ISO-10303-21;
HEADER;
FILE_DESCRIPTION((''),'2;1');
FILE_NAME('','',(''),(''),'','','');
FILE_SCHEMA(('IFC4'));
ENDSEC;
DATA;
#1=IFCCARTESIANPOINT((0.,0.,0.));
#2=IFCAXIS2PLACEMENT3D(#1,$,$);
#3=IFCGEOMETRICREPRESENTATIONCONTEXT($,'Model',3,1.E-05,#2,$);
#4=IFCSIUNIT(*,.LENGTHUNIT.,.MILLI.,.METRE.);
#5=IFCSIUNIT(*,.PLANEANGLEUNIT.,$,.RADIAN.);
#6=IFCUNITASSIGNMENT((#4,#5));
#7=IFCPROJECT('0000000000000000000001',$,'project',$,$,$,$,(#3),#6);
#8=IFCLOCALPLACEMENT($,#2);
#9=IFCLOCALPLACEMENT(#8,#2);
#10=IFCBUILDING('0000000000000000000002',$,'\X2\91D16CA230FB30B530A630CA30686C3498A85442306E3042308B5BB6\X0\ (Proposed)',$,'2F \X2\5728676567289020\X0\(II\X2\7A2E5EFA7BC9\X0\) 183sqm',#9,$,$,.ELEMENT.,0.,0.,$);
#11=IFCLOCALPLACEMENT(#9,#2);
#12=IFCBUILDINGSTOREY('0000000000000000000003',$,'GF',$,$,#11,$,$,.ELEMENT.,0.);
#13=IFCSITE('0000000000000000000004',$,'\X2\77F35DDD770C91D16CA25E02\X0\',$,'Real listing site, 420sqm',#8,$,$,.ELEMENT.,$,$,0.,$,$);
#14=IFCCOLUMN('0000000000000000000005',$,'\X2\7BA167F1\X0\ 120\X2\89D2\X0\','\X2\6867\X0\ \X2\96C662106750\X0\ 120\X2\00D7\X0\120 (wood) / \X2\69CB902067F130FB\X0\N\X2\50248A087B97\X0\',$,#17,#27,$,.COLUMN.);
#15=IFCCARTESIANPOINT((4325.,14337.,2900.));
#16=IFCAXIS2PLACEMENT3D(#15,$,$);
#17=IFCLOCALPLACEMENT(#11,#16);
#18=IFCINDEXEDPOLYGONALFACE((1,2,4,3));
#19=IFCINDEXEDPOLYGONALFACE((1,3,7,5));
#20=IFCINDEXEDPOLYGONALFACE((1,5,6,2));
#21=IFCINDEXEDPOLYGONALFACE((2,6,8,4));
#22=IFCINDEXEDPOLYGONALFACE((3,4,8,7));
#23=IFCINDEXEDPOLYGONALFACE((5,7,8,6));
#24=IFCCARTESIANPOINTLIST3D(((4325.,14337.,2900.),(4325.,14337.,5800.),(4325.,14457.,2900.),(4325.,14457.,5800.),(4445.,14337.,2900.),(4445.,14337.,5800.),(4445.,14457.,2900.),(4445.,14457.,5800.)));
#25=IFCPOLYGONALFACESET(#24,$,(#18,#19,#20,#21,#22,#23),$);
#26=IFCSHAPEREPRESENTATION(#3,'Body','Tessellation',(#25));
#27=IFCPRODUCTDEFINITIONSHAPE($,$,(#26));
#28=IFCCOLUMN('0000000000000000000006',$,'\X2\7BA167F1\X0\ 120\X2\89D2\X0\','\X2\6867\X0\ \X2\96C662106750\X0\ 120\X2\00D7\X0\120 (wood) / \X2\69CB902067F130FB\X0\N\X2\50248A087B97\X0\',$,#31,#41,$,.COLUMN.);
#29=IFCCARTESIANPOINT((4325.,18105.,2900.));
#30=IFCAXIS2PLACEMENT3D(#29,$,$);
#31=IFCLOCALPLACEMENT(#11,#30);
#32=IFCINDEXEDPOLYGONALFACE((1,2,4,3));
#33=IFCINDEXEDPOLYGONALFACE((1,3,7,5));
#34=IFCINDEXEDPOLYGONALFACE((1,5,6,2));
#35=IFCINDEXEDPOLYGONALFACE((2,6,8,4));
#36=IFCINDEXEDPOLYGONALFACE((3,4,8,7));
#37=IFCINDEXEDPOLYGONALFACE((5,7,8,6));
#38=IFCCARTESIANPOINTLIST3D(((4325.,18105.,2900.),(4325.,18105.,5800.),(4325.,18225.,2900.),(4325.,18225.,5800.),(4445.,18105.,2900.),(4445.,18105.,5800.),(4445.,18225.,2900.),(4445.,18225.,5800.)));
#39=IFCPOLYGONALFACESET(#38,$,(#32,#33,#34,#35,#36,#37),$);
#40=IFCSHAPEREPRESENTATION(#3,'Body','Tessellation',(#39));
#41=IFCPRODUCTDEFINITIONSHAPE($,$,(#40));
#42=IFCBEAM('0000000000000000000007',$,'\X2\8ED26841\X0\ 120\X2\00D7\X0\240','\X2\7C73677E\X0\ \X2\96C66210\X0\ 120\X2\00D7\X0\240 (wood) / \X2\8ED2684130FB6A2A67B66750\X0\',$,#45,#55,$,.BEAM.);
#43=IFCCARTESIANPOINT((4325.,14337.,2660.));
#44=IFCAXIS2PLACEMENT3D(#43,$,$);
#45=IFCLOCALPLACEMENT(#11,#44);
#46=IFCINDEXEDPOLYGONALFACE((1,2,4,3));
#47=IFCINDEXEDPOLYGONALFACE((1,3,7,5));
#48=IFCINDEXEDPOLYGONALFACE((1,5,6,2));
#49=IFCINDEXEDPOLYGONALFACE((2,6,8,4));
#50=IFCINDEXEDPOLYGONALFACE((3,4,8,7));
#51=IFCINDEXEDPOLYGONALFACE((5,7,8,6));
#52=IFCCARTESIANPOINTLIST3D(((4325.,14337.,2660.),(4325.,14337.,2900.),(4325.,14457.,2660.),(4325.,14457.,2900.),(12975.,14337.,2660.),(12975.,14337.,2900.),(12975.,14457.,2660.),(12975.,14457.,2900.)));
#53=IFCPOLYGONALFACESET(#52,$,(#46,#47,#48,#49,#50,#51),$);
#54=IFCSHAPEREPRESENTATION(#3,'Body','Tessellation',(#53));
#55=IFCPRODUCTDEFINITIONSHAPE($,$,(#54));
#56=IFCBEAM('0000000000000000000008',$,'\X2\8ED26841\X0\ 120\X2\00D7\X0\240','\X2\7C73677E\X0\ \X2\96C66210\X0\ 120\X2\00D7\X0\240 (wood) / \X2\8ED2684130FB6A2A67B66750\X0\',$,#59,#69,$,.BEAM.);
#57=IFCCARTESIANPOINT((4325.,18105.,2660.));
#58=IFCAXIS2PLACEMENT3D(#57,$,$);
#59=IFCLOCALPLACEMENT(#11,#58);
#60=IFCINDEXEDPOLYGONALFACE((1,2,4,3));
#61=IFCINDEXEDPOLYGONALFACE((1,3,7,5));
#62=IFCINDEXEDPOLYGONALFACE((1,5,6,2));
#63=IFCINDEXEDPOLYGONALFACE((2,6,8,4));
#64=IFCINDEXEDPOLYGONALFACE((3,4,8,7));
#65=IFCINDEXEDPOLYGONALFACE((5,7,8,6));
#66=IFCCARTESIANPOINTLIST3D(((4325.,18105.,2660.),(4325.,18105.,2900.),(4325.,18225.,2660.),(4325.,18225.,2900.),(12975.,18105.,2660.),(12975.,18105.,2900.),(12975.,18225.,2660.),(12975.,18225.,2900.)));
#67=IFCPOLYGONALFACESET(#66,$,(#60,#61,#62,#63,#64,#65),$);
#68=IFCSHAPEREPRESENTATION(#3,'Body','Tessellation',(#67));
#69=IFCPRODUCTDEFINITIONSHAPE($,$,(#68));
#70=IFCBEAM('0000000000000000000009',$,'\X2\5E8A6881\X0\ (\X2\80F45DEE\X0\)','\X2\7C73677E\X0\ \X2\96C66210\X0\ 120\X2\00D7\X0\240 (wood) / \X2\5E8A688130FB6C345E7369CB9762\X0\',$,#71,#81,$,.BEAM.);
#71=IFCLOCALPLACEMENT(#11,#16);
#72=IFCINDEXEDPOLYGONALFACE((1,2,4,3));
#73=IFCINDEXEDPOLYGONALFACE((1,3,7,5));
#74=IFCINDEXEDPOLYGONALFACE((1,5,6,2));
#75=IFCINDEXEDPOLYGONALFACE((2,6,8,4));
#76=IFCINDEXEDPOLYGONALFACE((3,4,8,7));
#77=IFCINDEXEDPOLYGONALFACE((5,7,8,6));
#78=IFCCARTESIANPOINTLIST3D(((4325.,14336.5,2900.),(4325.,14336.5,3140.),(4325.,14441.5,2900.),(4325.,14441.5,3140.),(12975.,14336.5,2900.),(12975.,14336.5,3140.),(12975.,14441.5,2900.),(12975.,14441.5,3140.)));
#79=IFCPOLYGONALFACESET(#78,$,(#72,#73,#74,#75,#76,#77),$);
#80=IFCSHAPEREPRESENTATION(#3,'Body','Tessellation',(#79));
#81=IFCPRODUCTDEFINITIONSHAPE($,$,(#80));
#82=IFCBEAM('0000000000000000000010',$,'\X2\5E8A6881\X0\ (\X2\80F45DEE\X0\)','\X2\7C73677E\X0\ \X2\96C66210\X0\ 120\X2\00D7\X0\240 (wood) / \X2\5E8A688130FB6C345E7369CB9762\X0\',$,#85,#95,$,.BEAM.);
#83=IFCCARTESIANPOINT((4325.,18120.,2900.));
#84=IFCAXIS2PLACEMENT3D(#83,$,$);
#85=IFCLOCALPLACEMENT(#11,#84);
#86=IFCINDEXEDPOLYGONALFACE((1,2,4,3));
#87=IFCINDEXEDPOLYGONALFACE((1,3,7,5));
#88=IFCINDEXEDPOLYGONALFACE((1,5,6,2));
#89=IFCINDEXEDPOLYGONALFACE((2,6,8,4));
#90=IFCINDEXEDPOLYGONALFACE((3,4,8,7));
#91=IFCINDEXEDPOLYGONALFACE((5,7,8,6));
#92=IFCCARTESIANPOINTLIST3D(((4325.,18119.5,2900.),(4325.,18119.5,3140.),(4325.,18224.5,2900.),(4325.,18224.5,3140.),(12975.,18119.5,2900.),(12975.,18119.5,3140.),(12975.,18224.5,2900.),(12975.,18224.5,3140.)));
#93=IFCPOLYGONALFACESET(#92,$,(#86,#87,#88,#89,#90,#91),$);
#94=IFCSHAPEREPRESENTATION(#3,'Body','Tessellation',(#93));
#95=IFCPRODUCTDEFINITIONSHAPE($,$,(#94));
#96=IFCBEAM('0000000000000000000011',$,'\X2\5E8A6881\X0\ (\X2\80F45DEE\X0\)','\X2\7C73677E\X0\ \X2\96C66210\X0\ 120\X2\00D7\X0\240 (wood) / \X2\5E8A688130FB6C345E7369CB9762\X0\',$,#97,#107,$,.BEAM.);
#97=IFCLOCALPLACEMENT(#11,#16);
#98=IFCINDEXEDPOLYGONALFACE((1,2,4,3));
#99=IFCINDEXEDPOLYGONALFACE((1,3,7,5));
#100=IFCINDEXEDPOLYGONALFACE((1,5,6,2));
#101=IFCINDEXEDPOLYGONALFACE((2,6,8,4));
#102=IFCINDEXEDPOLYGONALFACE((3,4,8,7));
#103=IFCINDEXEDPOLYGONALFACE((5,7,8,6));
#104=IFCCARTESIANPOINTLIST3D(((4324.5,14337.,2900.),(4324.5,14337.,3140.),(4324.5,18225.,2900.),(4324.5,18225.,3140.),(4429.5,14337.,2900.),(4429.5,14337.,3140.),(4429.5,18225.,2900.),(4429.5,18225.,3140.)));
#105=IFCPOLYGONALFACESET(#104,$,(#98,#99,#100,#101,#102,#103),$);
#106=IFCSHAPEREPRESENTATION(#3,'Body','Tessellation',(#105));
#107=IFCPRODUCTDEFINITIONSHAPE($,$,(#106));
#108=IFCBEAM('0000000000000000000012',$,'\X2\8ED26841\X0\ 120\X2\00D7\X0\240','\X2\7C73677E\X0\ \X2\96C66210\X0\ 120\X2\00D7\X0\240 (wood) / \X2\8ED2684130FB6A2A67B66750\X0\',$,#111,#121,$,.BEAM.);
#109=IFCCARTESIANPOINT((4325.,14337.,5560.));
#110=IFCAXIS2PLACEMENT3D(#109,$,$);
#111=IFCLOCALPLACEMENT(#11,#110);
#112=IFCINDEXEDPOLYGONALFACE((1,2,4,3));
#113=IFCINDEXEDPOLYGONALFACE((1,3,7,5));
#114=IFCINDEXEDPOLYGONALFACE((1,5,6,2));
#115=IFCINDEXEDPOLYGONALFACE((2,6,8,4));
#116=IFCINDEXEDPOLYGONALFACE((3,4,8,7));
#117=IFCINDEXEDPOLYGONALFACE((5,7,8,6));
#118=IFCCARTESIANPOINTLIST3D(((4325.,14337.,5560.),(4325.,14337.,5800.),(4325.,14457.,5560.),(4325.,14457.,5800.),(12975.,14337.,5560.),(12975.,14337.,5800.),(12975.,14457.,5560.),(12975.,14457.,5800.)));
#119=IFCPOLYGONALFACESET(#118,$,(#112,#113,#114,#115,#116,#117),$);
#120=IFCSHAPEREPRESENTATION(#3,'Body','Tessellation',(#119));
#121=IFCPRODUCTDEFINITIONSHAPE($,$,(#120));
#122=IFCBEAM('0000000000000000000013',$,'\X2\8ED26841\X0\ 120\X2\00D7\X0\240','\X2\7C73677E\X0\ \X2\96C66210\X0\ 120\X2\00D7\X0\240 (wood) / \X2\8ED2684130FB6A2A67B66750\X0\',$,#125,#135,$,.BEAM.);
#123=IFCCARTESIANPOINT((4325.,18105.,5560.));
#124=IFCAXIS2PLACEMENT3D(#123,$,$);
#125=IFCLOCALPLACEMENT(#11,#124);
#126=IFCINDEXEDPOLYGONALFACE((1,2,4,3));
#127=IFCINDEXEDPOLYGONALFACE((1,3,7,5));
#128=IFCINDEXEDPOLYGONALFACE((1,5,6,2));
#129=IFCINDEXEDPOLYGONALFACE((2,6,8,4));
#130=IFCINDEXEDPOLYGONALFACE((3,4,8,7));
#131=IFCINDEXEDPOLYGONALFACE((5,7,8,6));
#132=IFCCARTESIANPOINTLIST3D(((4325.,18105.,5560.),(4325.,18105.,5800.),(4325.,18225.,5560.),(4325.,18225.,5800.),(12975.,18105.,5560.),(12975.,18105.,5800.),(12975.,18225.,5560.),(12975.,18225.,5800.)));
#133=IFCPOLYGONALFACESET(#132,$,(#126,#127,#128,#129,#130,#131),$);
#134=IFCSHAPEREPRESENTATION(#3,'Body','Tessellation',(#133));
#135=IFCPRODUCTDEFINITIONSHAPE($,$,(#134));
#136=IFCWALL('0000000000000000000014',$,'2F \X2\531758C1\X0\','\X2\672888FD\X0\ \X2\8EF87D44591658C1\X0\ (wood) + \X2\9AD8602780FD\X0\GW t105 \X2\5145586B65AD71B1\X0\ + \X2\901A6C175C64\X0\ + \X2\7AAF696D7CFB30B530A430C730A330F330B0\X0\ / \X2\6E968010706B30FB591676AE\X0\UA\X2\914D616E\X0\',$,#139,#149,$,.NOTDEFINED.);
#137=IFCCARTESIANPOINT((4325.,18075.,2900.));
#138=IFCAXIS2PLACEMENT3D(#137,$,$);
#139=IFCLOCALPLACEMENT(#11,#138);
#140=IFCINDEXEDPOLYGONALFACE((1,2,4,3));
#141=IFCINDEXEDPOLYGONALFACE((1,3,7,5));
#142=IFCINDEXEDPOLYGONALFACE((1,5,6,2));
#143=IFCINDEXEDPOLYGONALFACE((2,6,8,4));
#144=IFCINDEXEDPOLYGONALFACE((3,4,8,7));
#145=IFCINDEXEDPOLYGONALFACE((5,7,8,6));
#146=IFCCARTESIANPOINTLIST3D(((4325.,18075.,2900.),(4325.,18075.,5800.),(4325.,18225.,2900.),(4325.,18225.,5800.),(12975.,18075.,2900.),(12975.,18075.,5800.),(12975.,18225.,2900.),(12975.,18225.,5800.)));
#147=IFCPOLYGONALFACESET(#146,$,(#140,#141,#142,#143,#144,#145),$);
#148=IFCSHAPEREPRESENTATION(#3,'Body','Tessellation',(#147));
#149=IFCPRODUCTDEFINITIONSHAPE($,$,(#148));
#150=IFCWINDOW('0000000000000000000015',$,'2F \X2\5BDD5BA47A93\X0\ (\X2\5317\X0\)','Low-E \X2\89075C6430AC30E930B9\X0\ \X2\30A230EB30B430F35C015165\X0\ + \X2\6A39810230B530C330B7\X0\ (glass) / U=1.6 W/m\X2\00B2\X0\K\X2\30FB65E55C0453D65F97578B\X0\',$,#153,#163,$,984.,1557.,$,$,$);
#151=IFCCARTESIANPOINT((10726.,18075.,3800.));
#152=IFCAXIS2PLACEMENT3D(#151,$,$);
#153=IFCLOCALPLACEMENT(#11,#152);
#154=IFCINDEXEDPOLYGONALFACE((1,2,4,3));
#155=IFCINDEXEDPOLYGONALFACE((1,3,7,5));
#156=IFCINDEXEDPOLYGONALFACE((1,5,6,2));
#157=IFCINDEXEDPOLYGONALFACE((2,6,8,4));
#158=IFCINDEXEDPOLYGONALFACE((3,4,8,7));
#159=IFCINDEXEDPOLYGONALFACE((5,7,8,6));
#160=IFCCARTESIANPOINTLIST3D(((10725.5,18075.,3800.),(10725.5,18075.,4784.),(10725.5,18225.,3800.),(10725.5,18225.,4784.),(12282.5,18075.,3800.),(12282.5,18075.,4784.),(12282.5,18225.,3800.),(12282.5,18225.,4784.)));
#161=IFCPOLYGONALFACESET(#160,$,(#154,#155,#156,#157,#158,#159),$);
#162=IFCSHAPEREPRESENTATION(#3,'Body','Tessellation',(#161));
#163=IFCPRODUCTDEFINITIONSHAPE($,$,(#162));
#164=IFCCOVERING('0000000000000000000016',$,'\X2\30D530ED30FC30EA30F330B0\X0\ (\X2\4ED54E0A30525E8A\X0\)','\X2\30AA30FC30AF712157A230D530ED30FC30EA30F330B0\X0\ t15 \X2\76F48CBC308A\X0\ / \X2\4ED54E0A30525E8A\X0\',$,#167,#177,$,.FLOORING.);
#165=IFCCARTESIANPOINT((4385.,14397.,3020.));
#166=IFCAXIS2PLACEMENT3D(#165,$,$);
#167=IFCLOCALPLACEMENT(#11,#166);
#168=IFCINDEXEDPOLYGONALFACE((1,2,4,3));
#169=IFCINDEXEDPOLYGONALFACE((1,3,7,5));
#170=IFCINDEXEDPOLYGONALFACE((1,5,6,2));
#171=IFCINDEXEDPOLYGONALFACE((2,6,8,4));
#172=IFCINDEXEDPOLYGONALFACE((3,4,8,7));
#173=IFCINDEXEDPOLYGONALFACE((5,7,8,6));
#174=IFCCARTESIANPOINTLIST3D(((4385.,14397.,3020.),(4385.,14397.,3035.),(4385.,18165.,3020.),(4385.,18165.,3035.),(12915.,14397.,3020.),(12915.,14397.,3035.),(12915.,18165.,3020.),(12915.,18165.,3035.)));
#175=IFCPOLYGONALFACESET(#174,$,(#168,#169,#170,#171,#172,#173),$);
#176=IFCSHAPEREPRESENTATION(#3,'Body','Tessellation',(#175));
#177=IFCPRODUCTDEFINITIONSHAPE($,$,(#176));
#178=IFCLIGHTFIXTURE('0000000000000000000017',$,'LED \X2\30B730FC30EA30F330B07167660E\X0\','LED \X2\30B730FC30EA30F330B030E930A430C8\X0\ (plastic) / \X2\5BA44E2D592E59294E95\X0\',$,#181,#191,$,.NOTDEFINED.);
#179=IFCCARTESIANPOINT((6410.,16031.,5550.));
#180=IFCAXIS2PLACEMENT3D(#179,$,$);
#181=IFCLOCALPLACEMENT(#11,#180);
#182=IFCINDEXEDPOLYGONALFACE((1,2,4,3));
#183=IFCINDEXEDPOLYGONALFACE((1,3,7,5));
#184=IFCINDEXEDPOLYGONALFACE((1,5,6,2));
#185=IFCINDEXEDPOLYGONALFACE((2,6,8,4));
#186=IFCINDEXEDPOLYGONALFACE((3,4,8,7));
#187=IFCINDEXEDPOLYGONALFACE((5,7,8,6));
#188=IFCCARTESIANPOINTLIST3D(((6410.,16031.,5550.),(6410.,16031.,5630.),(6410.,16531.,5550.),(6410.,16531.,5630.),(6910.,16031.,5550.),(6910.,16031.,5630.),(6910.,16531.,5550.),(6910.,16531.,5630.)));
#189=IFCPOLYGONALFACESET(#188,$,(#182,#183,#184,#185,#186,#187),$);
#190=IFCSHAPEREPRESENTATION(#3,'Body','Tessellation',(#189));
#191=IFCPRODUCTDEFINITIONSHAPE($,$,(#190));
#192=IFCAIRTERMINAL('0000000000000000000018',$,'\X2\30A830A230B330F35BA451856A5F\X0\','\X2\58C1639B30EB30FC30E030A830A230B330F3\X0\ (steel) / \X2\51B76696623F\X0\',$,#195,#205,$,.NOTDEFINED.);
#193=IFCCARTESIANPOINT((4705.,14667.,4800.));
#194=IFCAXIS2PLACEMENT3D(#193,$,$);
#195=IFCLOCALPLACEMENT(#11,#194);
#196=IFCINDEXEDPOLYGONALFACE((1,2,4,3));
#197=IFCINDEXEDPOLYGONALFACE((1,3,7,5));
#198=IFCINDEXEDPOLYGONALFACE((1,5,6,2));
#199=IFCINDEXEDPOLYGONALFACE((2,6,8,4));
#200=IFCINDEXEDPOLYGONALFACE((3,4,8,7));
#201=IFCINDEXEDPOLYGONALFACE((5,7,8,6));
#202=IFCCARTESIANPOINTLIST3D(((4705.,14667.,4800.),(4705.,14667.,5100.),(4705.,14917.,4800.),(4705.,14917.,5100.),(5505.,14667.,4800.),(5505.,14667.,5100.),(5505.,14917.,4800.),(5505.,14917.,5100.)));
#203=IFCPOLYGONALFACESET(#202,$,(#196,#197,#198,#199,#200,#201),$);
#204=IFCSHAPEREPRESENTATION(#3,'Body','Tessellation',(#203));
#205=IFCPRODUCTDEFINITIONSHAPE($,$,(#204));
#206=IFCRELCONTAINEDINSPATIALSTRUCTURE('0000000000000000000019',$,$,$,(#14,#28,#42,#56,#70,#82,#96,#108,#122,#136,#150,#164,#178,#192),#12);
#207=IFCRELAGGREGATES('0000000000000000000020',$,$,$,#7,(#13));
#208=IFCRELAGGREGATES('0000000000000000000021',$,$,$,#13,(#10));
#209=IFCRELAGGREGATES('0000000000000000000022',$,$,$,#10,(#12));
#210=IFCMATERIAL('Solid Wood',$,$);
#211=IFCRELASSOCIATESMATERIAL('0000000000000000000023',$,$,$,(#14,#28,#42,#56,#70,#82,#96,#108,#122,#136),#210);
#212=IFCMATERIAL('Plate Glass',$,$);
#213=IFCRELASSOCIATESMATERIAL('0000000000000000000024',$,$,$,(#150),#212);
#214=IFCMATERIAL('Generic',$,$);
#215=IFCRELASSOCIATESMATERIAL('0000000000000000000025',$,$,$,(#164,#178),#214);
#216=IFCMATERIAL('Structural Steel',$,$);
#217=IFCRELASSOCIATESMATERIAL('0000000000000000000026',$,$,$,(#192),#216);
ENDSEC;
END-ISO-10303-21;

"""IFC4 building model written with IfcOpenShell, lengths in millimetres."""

from ifc_helpers import new_model, si_unit, frame, frame_2d, origin, place, context, project, spatial, rectangle, extrude, material, element, fill, save


model = new_model("IFC4")

# Units and contexts
model_context = context("Model", 3, precision=1e-05, world=origin())
ifc_project = project(units=[si_unit("LENGTHUNIT", "METRE", prefix="MILLI"), si_unit("PLANEANGLEUNIT", "RADIAN")], contexts=[model_context])

# Site, building, storey
site_placement = place(None, origin())
site = spatial("IfcSite", under=ifc_project, at=site_placement, Name="石川県金沢市", ObjectType="Real listing site, 420sqm", CompositionType="ELEMENT", RefElevation=0.0)
building_placement = place(site_placement, origin())
building = spatial("IfcBuilding", under=site, at=building_placement, Name="金沢・サウナと水風呂のある家 (Proposed)", ObjectType="2F 在来木造(II種建築) 183sqm", CompositionType="ELEMENT", ElevationOfRefHeight=0.0, ElevationOfTerrain=0.0)
storey_placement = place(building_placement, origin())
storey = spatial("IfcBuildingStorey", under=building, at=storey_placement, Name="GF", CompositionType="ELEMENT", Elevation=0.0)

# Columns
ifc_material_1 = material(Name="Solid Wood")
column_1_placement = place(storey_placement, frame((4325.0, 14337.0, 2900.0)))
element("IfcColumn", 1, at=column_1_placement, inside=storey, material=ifc_material_1, Name="管柱 120角", Description="桧 集成材 120×120 (wood) / 構造柱・N値計算", PredefinedType="COLUMN", context=model_context, shape_type="SweptSolid", body=[
    extrude(rectangle(XDim=120.0, YDim=120.0, at=frame_2d((60.0, 60.0))), frame((4325.0, 14337.0, 2900.0)), (0.0, 0.0, 1.0), 2900.0),
])
column_2_placement = place(storey_placement, frame((4325.0, 18105.0, 2900.0)))
element("IfcColumn", 2, at=column_2_placement, inside=storey, material=ifc_material_1, Name="管柱 120角", Description="桧 集成材 120×120 (wood) / 構造柱・N値計算", PredefinedType="COLUMN", context=model_context, shape_type="SweptSolid", body=[
    extrude(rectangle(XDim=120.0, YDim=120.0, at=frame_2d((60.0, 60.0))), frame((4325.0, 18105.0, 2900.0)), (0.0, 0.0, 1.0), 2900.0),
])

# Beams
beam_1_placement = place(storey_placement, frame((4325.0, 14337.0, 2660.0)))
element("IfcBeam", 3, at=beam_1_placement, inside=storey, material=ifc_material_1, Name="軒桁 120×240", Description="米松 集成 120×240 (wood) / 軒桁・横架材", PredefinedType="BEAM", context=model_context, shape_type="SweptSolid", body=[
    extrude(rectangle(XDim=8650.0, YDim=120.0, at=frame_2d((4325.0, 60.0))), frame((4325.0, 14337.0, 2660.0)), (0.0, 0.0, 1.0), 240.0),
])
beam_2_placement = place(storey_placement, frame((4325.0, 18105.0, 2660.0)))
element("IfcBeam", 4, at=beam_2_placement, inside=storey, material=ifc_material_1, Name="軒桁 120×240", Description="米松 集成 120×240 (wood) / 軒桁・横架材", PredefinedType="BEAM", context=model_context, shape_type="SweptSolid", body=[
    extrude(rectangle(XDim=8650.0, YDim=120.0, at=frame_2d((4325.0, 60.0))), frame((4325.0, 18105.0, 2660.0)), (0.0, 0.0, 1.0), 240.0),
])
beam_3_placement = place(storey_placement, frame((4325.0, 14337.0, 2900.0)))
element("IfcBeam", 5, at=beam_3_placement, inside=storey, material=ifc_material_1, Name="床梁 (胴差)", Description="米松 集成 120×240 (wood) / 床梁・水平構面", PredefinedType="BEAM", context=model_context, shape_type="SweptSolid", body=[
    extrude(rectangle(XDim=8650.0, YDim=105.0, at=frame_2d((4325.0, 52.0))), frame((4325.0, 14337.0, 2900.0)), (0.0, 0.0, 1.0), 240.0),
])
beam_4_placement = place(storey_placement, frame((4325.0, 18120.0, 2900.0)))
element("IfcBeam", 6, at=beam_4_placement, inside=storey, material=ifc_material_1, Name="床梁 (胴差)", Description="米松 集成 120×240 (wood) / 床梁・水平構面", PredefinedType="BEAM", context=model_context, shape_type="SweptSolid", body=[
    extrude(rectangle(XDim=8650.0, YDim=105.0, at=frame_2d((4325.0, 52.0))), frame((4325.0, 18120.0, 2900.0)), (0.0, 0.0, 1.0), 240.0),
])
beam_5_placement = place(storey_placement, frame((4325.0, 14337.0, 2900.0)))
element("IfcBeam", 7, at=beam_5_placement, inside=storey, material=ifc_material_1, Name="床梁 (胴差)", Description="米松 集成 120×240 (wood) / 床梁・水平構面", PredefinedType="BEAM", context=model_context, shape_type="SweptSolid", body=[
    extrude(rectangle(XDim=105.0, YDim=3888.0, at=frame_2d((52.0, 1944.0))), frame((4325.0, 14337.0, 2900.0)), (0.0, 0.0, 1.0), 240.0),
])
beam_6_placement = place(storey_placement, frame((4325.0, 14337.0, 5560.0)))
element("IfcBeam", 8, at=beam_6_placement, inside=storey, material=ifc_material_1, Name="軒桁 120×240", Description="米松 集成 120×240 (wood) / 軒桁・横架材", PredefinedType="BEAM", context=model_context, shape_type="SweptSolid", body=[
    extrude(rectangle(XDim=8650.0, YDim=120.0, at=frame_2d((4325.0, 60.0))), frame((4325.0, 14337.0, 5560.0)), (0.0, 0.0, 1.0), 240.0),
])
beam_7_placement = place(storey_placement, frame((4325.0, 18105.0, 5560.0)))
element("IfcBeam", 9, at=beam_7_placement, inside=storey, material=ifc_material_1, Name="軒桁 120×240", Description="米松 集成 120×240 (wood) / 軒桁・横架材", PredefinedType="BEAM", context=model_context, shape_type="SweptSolid", body=[
    extrude(rectangle(XDim=8650.0, YDim=120.0, at=frame_2d((4325.0, 60.0))), frame((4325.0, 18105.0, 5560.0)), (0.0, 0.0, 1.0), 240.0),
])

# Wall, opening, window
wall_placement = place(storey_placement, frame((4325.0, 18075.0, 2900.0)))
wall = element("IfcWall", 10, at=wall_placement, inside=storey, material=ifc_material_1, Name="2F 北壁", Description="木製 軸組外壁 (wood) + 高性能GW t105 充填断熱 + 通気層 + 窯業系サイディング / 準耐火・外皮UA配慮", PredefinedType="NOTDEFINED", context=model_context, shape_type="SweptSolid", body=[
    extrude(rectangle(XDim=8650.0, YDim=150.0, at=frame_2d((4325.0, 75.0))), frame((4325.0, 18075.0, 2900.0)), (0.0, 0.0, 1.0), 2900.0),
])
opening_placement = place(storey_placement, frame((10726.0, 18075.0, 3800.0)))
opening = element("IfcOpeningElement", 11, at=opening_placement, cuts=wall, PredefinedType="NOTDEFINED", context=model_context, shape_type="SweptSolid", body=[
    extrude(rectangle(XDim=1557.0, YDim=150.0, at=frame_2d((778.0, 75.0))), frame((10726.0, 18075.0, 3800.0)), (0.0, 0.0, 1.0), 984.0),
])
ifc_material_2 = material(Name="Plate Glass")
window_placement = place(storey_placement, frame((10726.0, 18075.0, 3800.0)))
window = element("IfcWindow", 12, at=window_placement, inside=storey, material=ifc_material_2, Name="2F 寝室窓 (北)", Description="Low-E 複層ガラス アルゴン封入 + 樹脂サッシ (glass) / U=1.6 W/m²K・日射取得型", OverallHeight=984.0, OverallWidth=1557.0, context=model_context, shape_type="SweptSolid", body=[
    extrude(rectangle(XDim=1557.0, YDim=150.0, at=frame_2d((778.0, 75.0))), frame((10726.0, 18075.0, 3800.0)), (0.0, 0.0, 1.0), 984.0),
])
fill(opening, window)

# Covering
ifc_material_3 = material(Name="Generic")
covering_placement = place(storey_placement, frame((4385.0, 14397.0, 3020.0)))
element("IfcCovering", 13, at=covering_placement, inside=storey, material=ifc_material_3, Name="フローリング (仕上げ床)", Description="オーク無垢フローリング t15 直貼り / 仕上げ床", PredefinedType="FLOORING", context=model_context, shape_type="SweptSolid", body=[
    extrude(rectangle(XDim=8530.0, YDim=3768.0, at=frame_2d((4265.0, 1884.0))), frame((4385.0, 14397.0, 3020.0)), (0.0, 0.0, 1.0), 15.0),
])

# Light fixture
light_fixture_placement = place(storey_placement, frame((6410.0, 16031.0, 5550.0)))
element("IfcLightFixture", 14, at=light_fixture_placement, inside=storey, material=ifc_material_3, Name="LED シーリング照明", Description="LED シーリングライト (plastic) / 室中央天井", PredefinedType="NOTDEFINED", context=model_context, shape_type="SweptSolid", body=[
    extrude(rectangle(XDim=500.0, YDim=500.0, at=frame_2d((250.0, 250.0))), frame((6410.0, 16031.0, 5550.0)), (0.0, 0.0, 1.0), 80.0),
])

# Air terminal
ifc_material_4 = material(Name="Structural Steel")
air_terminal_placement = place(storey_placement, frame((4705.0, 14667.0, 4800.0)))
element("IfcAirTerminal", 15, at=air_terminal_placement, inside=storey, material=ifc_material_4, Name="エアコン室内機", Description="壁掛ルームエアコン (steel) / 冷暖房", PredefinedType="NOTDEFINED", context=model_context, shape_type="SweptSolid", body=[
    extrude(rectangle(XDim=800.0, YDim=250.0, at=frame_2d((400.0, 125.0))), frame((4705.0, 14667.0, 4800.0)), (0.0, 0.0, 1.0), 300.0),
])

save(model, "model.ifc")
